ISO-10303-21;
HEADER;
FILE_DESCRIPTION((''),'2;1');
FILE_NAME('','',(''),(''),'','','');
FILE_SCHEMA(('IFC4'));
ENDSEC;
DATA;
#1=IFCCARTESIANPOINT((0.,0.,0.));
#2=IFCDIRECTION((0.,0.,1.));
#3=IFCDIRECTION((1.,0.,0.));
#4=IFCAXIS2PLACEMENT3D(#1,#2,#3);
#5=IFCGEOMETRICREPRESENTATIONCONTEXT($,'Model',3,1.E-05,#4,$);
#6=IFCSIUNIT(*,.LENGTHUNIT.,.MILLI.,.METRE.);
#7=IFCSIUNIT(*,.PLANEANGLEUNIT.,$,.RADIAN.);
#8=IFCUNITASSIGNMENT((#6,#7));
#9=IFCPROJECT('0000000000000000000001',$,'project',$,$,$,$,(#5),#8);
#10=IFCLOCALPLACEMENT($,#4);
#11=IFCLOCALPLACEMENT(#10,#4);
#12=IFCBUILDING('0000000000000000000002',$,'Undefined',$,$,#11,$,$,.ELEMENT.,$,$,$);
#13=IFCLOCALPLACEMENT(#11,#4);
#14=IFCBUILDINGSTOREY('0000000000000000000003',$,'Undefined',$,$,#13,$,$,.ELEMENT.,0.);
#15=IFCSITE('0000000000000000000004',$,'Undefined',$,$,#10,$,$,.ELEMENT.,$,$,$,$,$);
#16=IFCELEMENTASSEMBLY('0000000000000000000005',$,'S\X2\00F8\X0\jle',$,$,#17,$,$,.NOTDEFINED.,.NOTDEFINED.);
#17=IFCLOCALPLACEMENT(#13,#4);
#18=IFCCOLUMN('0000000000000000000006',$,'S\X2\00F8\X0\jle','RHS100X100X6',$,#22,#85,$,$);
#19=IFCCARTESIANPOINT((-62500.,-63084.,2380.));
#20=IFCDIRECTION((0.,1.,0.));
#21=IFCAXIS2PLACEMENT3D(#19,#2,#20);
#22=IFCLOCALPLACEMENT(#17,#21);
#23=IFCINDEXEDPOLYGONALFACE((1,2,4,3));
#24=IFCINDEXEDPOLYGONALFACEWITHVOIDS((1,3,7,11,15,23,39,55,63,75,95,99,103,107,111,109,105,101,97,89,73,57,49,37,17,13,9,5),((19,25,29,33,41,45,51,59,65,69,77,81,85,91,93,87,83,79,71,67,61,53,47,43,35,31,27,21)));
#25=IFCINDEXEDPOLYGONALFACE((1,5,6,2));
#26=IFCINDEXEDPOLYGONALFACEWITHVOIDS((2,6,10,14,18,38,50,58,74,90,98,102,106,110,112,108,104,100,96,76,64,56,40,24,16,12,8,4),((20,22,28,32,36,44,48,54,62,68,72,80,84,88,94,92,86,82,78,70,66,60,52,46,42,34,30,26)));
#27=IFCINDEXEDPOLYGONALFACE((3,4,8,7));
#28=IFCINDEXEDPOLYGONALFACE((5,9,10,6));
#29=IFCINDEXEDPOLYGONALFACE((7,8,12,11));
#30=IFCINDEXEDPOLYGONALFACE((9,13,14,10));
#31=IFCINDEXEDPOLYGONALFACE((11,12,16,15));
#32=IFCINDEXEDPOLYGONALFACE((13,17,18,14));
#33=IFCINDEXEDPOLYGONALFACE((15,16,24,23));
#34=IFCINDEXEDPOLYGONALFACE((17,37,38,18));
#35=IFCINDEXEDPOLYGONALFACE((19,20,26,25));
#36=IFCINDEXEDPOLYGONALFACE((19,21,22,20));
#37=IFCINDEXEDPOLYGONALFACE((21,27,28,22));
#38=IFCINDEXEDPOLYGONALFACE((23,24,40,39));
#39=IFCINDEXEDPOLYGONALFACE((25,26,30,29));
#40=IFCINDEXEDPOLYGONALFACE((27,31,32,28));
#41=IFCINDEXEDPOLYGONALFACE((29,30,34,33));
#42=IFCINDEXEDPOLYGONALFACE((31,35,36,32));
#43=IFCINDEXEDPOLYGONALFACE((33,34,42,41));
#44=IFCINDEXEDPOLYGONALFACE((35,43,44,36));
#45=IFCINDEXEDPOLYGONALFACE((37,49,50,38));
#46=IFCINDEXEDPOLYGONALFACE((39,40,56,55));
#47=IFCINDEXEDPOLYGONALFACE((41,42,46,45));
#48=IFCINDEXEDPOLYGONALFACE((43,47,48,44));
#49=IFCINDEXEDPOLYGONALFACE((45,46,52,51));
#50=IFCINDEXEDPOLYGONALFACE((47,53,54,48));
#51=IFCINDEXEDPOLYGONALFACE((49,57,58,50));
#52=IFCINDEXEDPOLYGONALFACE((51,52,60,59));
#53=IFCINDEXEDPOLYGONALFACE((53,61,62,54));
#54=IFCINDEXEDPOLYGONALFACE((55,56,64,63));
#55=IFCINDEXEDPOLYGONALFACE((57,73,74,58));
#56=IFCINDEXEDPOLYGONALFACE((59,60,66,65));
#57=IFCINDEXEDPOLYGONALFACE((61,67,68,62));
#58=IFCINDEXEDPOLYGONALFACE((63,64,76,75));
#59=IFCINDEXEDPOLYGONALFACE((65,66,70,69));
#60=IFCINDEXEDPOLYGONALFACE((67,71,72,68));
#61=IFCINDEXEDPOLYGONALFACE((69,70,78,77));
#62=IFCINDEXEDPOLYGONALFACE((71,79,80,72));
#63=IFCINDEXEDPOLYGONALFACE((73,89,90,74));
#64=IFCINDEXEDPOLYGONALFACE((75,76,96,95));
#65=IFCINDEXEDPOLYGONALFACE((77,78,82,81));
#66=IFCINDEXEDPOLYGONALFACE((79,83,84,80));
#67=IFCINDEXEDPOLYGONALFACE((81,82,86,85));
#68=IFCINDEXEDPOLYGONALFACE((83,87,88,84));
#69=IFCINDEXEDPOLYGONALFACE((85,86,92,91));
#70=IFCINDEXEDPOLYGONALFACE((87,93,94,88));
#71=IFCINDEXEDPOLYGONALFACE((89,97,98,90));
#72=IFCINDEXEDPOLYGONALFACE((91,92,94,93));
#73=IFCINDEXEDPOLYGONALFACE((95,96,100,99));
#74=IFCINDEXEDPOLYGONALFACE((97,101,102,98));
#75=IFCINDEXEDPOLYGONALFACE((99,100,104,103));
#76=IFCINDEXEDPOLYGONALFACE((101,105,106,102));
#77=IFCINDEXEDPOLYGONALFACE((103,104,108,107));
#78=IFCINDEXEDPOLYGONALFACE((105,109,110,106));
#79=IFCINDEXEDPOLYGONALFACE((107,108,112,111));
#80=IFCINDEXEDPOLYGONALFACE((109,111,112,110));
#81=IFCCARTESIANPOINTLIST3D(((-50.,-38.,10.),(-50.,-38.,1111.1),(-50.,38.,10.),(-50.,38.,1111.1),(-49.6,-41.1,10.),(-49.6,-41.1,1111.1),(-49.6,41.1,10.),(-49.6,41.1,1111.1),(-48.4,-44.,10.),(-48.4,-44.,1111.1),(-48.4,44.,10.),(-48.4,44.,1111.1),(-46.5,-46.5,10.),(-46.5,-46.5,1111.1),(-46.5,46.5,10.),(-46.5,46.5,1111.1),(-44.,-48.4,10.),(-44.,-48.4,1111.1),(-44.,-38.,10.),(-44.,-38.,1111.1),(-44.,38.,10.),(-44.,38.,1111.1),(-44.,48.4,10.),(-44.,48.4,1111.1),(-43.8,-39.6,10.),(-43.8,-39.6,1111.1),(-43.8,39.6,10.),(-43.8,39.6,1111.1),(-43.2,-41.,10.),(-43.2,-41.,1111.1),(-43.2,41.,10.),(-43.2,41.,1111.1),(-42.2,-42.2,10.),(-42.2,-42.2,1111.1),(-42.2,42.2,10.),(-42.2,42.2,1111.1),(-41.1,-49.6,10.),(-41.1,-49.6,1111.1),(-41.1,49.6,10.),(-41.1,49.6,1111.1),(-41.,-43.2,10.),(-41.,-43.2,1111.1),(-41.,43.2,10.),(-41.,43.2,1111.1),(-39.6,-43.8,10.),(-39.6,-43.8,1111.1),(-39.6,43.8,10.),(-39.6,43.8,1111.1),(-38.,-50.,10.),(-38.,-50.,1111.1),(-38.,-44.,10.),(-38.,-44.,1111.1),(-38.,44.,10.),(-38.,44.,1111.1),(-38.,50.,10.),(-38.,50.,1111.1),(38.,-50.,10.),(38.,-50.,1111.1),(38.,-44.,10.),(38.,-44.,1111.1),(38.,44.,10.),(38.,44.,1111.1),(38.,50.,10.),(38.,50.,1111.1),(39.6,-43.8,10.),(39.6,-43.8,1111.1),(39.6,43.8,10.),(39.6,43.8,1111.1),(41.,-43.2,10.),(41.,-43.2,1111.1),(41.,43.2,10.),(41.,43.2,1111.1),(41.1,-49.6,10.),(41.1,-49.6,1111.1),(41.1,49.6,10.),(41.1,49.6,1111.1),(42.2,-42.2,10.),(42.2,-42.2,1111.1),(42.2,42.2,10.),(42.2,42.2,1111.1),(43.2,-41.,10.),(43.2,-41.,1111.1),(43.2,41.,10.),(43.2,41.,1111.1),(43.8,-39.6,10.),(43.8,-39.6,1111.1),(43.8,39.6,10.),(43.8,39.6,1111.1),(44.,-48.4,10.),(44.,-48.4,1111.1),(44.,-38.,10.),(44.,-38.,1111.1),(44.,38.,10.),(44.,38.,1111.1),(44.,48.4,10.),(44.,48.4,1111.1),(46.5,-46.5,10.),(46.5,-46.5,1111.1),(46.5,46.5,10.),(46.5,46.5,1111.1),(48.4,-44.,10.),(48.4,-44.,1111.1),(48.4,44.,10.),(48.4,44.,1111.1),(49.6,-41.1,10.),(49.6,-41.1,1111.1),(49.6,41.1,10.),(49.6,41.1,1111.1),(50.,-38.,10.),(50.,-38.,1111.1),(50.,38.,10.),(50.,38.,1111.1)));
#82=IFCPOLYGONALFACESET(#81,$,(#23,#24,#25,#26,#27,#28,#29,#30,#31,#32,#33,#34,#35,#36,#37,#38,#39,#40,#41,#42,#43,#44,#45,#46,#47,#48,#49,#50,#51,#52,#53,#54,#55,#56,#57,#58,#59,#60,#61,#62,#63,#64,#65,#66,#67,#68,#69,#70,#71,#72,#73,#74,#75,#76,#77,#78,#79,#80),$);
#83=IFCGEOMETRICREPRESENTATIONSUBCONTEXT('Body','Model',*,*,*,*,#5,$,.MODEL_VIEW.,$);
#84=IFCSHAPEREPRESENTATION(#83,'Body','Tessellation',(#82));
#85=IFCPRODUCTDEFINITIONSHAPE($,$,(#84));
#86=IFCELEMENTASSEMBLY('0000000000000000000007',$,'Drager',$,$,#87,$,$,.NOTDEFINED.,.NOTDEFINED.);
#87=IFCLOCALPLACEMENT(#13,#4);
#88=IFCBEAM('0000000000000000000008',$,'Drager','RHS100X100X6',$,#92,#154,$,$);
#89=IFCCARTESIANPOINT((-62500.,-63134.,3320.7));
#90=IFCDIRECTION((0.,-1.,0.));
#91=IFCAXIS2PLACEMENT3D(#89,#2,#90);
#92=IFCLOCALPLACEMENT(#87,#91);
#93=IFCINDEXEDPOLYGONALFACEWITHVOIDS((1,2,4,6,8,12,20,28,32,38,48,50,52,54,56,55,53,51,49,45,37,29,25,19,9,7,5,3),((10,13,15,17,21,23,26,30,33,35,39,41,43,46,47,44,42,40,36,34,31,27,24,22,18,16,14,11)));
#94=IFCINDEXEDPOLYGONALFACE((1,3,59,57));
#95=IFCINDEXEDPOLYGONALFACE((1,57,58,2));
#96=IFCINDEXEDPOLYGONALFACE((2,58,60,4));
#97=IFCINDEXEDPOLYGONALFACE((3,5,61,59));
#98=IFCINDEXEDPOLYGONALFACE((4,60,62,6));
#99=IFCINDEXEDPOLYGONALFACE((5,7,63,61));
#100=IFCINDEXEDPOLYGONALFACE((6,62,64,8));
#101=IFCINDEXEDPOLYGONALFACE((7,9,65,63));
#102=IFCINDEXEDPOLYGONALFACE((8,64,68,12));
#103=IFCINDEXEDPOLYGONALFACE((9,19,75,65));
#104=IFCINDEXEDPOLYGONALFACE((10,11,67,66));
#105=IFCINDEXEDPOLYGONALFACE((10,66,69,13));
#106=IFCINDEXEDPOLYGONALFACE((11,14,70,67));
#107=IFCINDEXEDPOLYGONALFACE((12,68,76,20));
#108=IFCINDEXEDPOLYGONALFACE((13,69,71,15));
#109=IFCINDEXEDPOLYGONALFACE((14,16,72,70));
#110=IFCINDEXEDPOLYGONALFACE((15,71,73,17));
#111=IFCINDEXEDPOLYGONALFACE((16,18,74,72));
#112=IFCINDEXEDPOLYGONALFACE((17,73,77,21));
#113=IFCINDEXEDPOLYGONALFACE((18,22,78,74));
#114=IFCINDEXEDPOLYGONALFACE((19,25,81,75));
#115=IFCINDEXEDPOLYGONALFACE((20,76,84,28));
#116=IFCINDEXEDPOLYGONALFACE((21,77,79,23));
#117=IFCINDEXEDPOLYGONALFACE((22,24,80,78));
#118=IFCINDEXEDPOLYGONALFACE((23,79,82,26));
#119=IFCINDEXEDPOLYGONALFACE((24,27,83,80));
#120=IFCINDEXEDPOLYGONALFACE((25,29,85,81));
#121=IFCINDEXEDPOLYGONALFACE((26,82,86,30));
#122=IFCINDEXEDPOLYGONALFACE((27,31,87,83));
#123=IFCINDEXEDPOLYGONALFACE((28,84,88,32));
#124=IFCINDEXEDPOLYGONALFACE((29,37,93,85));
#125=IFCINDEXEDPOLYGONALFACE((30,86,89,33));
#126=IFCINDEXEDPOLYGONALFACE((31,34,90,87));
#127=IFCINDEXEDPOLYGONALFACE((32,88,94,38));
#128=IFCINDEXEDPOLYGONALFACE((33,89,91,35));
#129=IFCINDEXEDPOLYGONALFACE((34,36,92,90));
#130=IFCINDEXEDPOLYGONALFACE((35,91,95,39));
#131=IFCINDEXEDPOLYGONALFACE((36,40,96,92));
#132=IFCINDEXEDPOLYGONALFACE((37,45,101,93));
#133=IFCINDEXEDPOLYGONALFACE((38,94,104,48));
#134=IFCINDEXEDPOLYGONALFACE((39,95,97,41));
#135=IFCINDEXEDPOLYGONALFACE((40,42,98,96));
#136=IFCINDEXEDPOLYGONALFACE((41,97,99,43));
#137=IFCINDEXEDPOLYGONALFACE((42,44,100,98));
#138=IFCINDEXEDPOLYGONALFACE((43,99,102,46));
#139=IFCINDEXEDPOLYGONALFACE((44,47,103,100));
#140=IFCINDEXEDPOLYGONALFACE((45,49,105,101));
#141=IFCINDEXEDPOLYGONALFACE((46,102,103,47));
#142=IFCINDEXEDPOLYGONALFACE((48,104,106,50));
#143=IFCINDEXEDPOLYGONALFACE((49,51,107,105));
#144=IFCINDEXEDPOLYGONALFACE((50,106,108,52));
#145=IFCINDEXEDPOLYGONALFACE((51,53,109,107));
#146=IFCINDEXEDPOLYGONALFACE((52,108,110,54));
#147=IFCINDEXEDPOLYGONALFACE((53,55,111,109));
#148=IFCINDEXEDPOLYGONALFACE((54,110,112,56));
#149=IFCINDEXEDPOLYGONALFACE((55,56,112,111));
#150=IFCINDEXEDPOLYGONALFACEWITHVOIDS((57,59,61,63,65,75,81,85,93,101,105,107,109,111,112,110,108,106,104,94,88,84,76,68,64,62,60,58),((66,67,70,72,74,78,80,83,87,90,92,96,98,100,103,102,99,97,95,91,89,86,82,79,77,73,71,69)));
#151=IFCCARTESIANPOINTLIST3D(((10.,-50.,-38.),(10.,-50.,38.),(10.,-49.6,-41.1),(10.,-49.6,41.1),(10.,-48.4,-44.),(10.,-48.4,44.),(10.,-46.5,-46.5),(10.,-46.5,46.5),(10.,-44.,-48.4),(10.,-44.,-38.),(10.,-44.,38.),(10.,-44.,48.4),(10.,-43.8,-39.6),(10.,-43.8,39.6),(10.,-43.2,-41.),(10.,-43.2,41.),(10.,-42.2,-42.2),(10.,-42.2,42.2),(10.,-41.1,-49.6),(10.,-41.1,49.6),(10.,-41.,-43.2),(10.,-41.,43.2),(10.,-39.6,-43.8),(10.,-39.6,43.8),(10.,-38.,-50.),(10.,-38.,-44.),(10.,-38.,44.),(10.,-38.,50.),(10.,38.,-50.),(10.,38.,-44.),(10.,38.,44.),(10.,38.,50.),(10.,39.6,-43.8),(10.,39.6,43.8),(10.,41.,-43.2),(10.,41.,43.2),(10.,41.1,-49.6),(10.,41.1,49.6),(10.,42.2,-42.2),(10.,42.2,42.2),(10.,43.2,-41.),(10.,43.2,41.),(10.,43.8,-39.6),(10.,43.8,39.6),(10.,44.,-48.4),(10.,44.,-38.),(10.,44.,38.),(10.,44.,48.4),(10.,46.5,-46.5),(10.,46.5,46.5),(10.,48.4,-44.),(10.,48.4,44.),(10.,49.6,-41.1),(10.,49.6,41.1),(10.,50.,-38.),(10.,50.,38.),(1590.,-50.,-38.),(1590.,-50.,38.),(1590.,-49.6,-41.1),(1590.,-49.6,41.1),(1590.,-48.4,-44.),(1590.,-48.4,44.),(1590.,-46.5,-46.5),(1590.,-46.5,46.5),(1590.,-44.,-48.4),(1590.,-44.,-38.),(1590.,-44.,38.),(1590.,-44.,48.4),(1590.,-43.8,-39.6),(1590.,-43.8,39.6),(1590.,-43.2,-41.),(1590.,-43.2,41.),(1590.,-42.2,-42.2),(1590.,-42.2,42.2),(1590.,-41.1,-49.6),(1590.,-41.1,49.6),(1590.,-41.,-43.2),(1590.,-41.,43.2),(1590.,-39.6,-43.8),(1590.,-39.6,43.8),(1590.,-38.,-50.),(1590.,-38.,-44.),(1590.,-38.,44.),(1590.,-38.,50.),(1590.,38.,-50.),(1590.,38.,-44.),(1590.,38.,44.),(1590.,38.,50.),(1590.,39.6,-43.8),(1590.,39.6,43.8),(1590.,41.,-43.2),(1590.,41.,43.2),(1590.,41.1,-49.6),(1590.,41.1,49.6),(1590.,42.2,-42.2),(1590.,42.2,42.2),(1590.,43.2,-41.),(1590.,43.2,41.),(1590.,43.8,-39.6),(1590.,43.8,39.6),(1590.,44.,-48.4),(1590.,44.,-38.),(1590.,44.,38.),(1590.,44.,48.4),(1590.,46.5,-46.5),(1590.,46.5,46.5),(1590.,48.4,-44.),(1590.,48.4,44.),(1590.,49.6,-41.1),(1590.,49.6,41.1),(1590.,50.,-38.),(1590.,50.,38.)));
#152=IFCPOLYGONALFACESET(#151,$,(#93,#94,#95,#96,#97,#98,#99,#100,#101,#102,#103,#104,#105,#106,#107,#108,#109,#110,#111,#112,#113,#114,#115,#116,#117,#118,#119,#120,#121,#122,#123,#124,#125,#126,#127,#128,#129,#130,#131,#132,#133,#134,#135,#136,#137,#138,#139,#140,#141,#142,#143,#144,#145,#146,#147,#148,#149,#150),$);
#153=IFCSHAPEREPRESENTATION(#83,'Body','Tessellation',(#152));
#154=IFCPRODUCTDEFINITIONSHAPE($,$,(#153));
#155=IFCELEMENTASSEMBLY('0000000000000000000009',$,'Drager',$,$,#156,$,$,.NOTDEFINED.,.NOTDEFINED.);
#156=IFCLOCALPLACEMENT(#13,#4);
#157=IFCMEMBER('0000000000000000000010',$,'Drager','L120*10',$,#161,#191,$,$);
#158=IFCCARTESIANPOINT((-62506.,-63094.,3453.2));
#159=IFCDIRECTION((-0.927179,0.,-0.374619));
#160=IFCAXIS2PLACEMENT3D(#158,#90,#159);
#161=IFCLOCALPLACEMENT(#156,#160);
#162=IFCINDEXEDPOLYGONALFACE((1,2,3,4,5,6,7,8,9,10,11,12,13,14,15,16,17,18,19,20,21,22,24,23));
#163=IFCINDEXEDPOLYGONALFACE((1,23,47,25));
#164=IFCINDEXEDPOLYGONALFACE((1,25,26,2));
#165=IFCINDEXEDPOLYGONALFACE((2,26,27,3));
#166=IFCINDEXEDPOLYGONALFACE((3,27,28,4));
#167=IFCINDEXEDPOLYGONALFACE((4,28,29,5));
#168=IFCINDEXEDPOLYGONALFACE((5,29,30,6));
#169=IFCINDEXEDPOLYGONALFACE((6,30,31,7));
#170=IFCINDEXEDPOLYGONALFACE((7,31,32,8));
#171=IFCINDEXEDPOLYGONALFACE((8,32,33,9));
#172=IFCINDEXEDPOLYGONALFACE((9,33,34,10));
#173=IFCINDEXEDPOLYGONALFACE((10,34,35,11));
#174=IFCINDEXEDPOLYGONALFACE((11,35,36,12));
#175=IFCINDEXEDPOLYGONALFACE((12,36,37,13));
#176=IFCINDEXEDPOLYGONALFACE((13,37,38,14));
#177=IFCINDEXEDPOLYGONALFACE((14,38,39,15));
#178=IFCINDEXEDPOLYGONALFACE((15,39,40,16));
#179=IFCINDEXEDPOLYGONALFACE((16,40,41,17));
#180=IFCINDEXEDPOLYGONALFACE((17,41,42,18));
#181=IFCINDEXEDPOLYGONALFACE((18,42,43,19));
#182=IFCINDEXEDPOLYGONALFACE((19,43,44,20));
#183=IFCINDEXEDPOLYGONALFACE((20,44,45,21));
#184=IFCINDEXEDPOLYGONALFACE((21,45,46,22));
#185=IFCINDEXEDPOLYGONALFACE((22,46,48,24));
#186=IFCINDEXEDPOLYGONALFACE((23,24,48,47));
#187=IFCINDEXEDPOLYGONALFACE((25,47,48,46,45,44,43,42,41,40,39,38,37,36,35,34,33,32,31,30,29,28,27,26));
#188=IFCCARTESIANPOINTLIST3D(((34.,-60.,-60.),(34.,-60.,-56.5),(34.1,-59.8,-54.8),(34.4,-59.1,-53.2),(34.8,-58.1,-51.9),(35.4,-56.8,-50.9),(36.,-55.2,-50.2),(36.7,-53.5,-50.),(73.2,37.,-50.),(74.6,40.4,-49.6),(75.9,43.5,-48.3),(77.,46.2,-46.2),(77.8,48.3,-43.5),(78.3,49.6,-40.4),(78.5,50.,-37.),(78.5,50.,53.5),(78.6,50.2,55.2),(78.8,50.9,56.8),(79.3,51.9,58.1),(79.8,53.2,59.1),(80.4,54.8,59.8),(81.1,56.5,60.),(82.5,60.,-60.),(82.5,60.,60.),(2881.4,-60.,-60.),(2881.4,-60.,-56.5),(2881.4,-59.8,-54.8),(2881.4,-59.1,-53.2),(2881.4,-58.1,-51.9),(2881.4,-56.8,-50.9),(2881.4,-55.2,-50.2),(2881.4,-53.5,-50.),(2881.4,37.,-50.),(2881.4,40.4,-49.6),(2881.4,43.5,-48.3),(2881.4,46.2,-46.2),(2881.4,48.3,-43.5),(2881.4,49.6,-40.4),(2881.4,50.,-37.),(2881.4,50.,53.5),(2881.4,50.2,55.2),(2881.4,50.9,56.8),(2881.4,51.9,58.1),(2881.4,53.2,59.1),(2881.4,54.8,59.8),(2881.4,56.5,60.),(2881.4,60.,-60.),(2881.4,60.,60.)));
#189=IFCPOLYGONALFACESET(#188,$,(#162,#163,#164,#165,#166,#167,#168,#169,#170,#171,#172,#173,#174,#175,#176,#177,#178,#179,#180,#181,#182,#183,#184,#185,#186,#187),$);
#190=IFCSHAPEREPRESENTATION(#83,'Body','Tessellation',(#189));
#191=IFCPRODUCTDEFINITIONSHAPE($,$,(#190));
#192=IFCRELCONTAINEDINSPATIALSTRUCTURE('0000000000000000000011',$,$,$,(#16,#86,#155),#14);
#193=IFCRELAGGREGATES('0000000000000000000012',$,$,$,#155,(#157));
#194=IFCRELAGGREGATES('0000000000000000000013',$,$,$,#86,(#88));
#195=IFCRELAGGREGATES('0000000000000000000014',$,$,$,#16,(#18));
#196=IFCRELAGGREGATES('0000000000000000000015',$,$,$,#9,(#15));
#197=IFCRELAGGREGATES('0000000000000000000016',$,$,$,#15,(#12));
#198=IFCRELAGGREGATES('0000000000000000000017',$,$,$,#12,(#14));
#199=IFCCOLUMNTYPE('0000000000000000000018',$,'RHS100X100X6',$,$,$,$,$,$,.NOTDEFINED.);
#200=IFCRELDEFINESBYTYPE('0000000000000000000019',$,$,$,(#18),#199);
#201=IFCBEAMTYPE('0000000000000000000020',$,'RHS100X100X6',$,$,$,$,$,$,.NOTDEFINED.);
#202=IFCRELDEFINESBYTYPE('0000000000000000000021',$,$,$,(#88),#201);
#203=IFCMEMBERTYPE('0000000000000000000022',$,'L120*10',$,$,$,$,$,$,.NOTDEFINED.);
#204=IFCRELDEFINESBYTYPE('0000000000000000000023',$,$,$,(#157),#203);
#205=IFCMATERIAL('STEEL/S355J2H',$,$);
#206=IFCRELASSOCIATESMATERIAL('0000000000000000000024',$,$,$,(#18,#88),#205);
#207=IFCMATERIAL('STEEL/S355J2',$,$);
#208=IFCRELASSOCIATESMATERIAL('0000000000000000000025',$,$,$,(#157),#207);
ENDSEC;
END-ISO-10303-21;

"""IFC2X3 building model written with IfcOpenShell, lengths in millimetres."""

from ifc_helpers import new_model, si_unit, frame, origin_with_axes, origin_2d_with_axis, place, context, subcontext, project, spatial, hollow_rectangle, l_section, extrude, clip, halfspace, material, type_object, element, aggregate, save


model = new_model("IFC2X3")

# Units and contexts
model_context = context("Model", 3, precision=1e-05, world=origin_with_axes())
body_context = subcontext(model_context, "Body", "Model", "MODEL_VIEW")
ifc_project = project(units=[si_unit("LENGTHUNIT", "METRE", prefix="MILLI"), si_unit("PLANEANGLEUNIT", "RADIAN")], contexts=[model_context])

# Site, building, storey
site_placement = place(None, origin_with_axes())
site = spatial("IfcSite", under=ifc_project, at=site_placement, Name="Undefined", CompositionType="ELEMENT")
building_placement = place(site_placement, origin_with_axes())
building = spatial("IfcBuilding", under=site, at=building_placement, Name="Undefined", CompositionType="ELEMENT")
storey_placement = place(building_placement, origin_with_axes())
storey = spatial("IfcBuildingStorey", under=building, at=storey_placement, Name="Undefined", CompositionType="ELEMENT", Elevation=0.0)

# Element assembly, column
assembly_1_placement = place(storey_placement, origin_with_axes())
assembly_1 = element("IfcElementAssembly", 1, at=assembly_1_placement, inside=storey, Name="Søjle", AssemblyPlace="NOTDEFINED", PredefinedType="NOTDEFINED")
ifc_material_1 = material(Name="STEEL/S355J2H")
column_type = type_object("IfcColumnType", Name="RHS100X100X6", PredefinedType="NOTDEFINED")
column_1_placement = place(assembly_1_placement, frame((-62500.0, -63084.0, 2380.0), z_axis=(0.0, 0.0, 1.0), x_axis=(0.0, 1.0, 0.0)))
column_1 = element("IfcColumn", 2, at=column_1_placement, type_object=column_type, material=ifc_material_1, Name="Søjle", Description="RHS100X100X6", context=body_context, shape_type="Clipping", body=[
    clip(clip(extrude(hollow_rectangle(XDim=100.0, YDim=100.0, WallThickness=6.0, InnerFilletRadius=6.0, OuterFilletRadius=12.0, at=origin_2d_with_axis()), frame((0.0, 0.0, 1111.1), z_axis=(0.0, 0.0, -1.0), x_axis=(0.0, 1.0, 0.0)), (0.0, 0.0, 1.0), 1111.1), halfspace(frame((-50.0, 0.0, 1111.1), z_axis=(0.0, 0.0, -1.0), x_axis=(0.0, -1.0, 0.0)), True)), halfspace(frame((0.0, -50.0, 10.0), z_axis=(0.0, 0.0, 1.0), x_axis=(-1.0, 0.0, 0.0)), True)),
])

# Element assembly, beam
assembly_2_placement = place(storey_placement, origin_with_axes())
assembly_2 = element("IfcElementAssembly", 3, at=assembly_2_placement, inside=storey, Name="Drager", AssemblyPlace="NOTDEFINED", PredefinedType="NOTDEFINED")
beam_type = type_object("IfcBeamType", Name="RHS100X100X6", PredefinedType="NOTDEFINED")
beam_1_placement = place(assembly_2_placement, frame((-62500.0, -63134.0, 3320.7), z_axis=(0.0, 0.0, 1.0), x_axis=(0.0, -1.0, 0.0)))
beam_1 = element("IfcBeam", 4, at=beam_1_placement, type_object=beam_type, material=ifc_material_1, Name="Drager", Description="RHS100X100X6", context=body_context, shape_type="Clipping", body=[
    clip(clip(extrude(hollow_rectangle(XDim=100.0, YDim=100.0, WallThickness=6.0, InnerFilletRadius=6.0, OuterFilletRadius=12.0, at=origin_2d_with_axis()), frame((1601.0, 0.0, 0.0), z_axis=(-1.0, 0.0, 0.0), x_axis=(0.0, -1.0, 0.0)), (0.0, 0.0, 1.0), 1601.0), halfspace(frame((1590.0, 0.0, 50.0), z_axis=(-1.0, 0.0, 0.0), x_axis=(0.0, -1.0, 0.0)), True)), halfspace(frame((10.0, 0.0, 50.0), z_axis=(1.0, 0.0, 0.0), x_axis=(0.0, 1.0, 0.0)), True)),
])

# Element assembly, member
assembly_3_placement = place(storey_placement, origin_with_axes())
assembly_3 = element("IfcElementAssembly", 5, at=assembly_3_placement, inside=storey, Name="Drager", AssemblyPlace="NOTDEFINED", PredefinedType="NOTDEFINED")
ifc_material_2 = material(Name="STEEL/S355J2")
member_type = type_object("IfcMemberType", Name="L120*10", PredefinedType="NOTDEFINED")
member_placement = place(assembly_3_placement, frame((-62506.0, -63094.0, 3453.2), z_axis=(0.0, -1.0, 0.0), x_axis=(-0.927179, 0.0, -0.374619)))
member = element("IfcMember", 6, at=member_placement, type_object=member_type, material=ifc_material_2, Name="Drager", Description="L120*10", context=body_context, shape_type="Clipping", body=[
    clip(clip(extrude(l_section(Depth=120.0, Width=120.0, Thickness=10.0, FilletRadius=13.0, EdgeRadius=6.5, at=origin_2d_with_axis()), frame((2948.0, 0.0, 0.0), z_axis=(-1.0, 0.0, 0.0), x_axis=(0.0, -1.0, 0.0)), (0.0, 0.0, 1.0), 2956.3), halfspace(frame((2881.4, 0.0, -60.0), z_axis=(-1.0, 0.0, 0.0), x_axis=(0.0, 1.0, 0.0)), True)), halfspace(frame((81.0, 56.3, 0.0), z_axis=(0.927179, -0.374619, 0.0), x_axis=(0.0, 0.0, -1.0)), True)),
])

aggregate(assembly_3, [member])

aggregate(assembly_2, [beam_1])
aggregate(assembly_1, [column_1])

save(model, "model.ifc")
